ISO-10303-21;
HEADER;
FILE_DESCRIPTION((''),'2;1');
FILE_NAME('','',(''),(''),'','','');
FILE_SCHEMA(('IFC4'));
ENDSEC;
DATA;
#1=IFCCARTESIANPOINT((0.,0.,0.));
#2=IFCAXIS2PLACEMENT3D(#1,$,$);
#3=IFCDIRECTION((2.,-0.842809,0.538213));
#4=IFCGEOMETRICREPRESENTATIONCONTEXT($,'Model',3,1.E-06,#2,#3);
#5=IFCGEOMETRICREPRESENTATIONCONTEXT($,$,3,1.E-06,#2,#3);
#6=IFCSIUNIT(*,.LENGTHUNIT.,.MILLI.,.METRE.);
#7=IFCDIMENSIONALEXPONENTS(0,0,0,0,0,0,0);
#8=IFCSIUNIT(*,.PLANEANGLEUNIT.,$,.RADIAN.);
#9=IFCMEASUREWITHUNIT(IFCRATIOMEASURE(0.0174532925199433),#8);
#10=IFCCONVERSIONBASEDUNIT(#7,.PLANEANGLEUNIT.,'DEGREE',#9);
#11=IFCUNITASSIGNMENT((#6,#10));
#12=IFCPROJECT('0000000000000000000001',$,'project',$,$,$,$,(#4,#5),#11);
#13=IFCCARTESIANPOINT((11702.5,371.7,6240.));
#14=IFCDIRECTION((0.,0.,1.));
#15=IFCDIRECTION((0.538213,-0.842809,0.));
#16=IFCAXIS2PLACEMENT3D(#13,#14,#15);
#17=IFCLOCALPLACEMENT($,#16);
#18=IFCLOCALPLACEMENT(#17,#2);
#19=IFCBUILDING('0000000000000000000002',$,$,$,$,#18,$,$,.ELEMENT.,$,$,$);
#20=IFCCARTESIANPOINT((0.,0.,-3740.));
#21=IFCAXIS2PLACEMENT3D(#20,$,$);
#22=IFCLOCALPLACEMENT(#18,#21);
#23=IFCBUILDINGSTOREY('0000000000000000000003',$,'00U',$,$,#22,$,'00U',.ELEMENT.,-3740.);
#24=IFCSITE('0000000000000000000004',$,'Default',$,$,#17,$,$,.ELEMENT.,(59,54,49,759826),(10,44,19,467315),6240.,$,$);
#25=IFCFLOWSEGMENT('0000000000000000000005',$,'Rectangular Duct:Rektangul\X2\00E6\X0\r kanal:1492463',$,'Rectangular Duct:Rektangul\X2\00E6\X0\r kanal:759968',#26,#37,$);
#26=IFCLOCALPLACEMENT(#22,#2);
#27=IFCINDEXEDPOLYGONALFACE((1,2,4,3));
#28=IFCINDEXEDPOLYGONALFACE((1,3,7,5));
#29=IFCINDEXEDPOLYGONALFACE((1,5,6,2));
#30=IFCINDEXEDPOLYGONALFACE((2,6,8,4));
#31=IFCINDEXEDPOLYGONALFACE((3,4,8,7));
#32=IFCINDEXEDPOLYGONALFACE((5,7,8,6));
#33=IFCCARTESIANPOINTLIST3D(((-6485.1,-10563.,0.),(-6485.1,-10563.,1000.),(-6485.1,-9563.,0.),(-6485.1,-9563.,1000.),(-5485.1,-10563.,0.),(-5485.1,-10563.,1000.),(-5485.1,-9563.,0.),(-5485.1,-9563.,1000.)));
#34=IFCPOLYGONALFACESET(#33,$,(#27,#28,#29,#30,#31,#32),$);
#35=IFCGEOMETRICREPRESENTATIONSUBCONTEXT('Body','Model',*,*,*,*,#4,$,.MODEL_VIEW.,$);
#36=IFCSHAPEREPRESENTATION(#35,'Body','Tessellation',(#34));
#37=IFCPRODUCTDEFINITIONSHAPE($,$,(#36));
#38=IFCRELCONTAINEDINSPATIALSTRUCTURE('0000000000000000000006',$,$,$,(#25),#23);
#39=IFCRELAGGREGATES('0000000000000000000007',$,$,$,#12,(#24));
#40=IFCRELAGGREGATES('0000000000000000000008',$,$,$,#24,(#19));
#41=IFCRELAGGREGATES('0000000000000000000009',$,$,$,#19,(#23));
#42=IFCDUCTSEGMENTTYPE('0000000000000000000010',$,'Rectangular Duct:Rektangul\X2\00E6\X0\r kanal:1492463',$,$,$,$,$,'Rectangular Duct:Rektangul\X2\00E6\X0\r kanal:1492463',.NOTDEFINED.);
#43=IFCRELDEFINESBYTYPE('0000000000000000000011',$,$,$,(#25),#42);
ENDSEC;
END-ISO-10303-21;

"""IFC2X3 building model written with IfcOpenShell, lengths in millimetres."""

from ifc_helpers import new_model, entity, si_unit, converted_unit, direction, frame, frame_2d, origin, place, context, subcontext, project, spatial, rectangle, extrude, type_object, element, save


model = new_model("IFC2X3")

# Units and contexts
model_context = context("Model", 3, precision=1e-06, world=origin(), true_north=direction((2.0, -0.842809, 0.538213)))
context_of_model = context(None, 3, precision=1e-06, world=origin(), true_north=direction((2.0, -0.842809, 0.538213)))
body_context = subcontext(model_context, "Body", "Model", "MODEL_VIEW")
ifc_project = project(units=[si_unit("LENGTHUNIT", "METRE", prefix="MILLI"), converted_unit("PLANEANGLEUNIT", "DEGREE", entity("IfcRatioMeasure", 0.0174532925199433), si_unit("PLANEANGLEUNIT", "RADIAN"), dimensions=[0, 0, 0, 0, 0, 0, 0])], contexts=[model_context, context_of_model])

# Site, building, storey
site_placement = place(None, frame((11702.5, 371.7, 6240.0), z_axis=(0.0, 0.0, 1.0), x_axis=(0.538213, -0.842809, 0.0)))
site = spatial("IfcSite", under=ifc_project, at=site_placement, Name="Default", CompositionType="ELEMENT", RefLatitude=(59, 54, 49, 759826), RefLongitude=(10, 44, 19, 467315), RefElevation=6240.0)
building_placement = place(site_placement, origin())
building = spatial("IfcBuilding", under=site, at=building_placement, CompositionType="ELEMENT")
storey_placement = place(building_placement, frame((0.0, 0.0, -3740.0)))
storey = spatial("IfcBuildingStorey", under=building, at=storey_placement, Name="00U", LongName="00U", CompositionType="ELEMENT", Elevation=-3740.0)

# Flow segment
duct_segment_type = type_object("IfcDuctSegmentType", Name="Rectangular Duct:Rektangulær kanal:1492463", ElementType="Rectangular Duct:Rektangulær kanal:1492463", PredefinedType="NOTDEFINED")
flow_segment_placement = place(storey_placement, origin())
element("IfcFlowSegment", 1, at=flow_segment_placement, inside=storey, type_object=duct_segment_type, Name="Rectangular Duct:Rektangulær kanal:1492463", ObjectType="Rectangular Duct:Rektangulær kanal:759968", context=body_context, shape_type="SweptSolid", body=[
    extrude(rectangle(XDim=1000.0, YDim=1000.0, at=frame_2d((0.0, 0.0), x_axis=(1.0, 0.0))), frame((-5985.1, -10063.0, 0.0), z_axis=(0.0, 0.0, 1.0), x_axis=(0.0, -1.0, 0.0)), (0.0, 0.0, 1.0), 1000.0),
])

save(model, "model.ifc")
